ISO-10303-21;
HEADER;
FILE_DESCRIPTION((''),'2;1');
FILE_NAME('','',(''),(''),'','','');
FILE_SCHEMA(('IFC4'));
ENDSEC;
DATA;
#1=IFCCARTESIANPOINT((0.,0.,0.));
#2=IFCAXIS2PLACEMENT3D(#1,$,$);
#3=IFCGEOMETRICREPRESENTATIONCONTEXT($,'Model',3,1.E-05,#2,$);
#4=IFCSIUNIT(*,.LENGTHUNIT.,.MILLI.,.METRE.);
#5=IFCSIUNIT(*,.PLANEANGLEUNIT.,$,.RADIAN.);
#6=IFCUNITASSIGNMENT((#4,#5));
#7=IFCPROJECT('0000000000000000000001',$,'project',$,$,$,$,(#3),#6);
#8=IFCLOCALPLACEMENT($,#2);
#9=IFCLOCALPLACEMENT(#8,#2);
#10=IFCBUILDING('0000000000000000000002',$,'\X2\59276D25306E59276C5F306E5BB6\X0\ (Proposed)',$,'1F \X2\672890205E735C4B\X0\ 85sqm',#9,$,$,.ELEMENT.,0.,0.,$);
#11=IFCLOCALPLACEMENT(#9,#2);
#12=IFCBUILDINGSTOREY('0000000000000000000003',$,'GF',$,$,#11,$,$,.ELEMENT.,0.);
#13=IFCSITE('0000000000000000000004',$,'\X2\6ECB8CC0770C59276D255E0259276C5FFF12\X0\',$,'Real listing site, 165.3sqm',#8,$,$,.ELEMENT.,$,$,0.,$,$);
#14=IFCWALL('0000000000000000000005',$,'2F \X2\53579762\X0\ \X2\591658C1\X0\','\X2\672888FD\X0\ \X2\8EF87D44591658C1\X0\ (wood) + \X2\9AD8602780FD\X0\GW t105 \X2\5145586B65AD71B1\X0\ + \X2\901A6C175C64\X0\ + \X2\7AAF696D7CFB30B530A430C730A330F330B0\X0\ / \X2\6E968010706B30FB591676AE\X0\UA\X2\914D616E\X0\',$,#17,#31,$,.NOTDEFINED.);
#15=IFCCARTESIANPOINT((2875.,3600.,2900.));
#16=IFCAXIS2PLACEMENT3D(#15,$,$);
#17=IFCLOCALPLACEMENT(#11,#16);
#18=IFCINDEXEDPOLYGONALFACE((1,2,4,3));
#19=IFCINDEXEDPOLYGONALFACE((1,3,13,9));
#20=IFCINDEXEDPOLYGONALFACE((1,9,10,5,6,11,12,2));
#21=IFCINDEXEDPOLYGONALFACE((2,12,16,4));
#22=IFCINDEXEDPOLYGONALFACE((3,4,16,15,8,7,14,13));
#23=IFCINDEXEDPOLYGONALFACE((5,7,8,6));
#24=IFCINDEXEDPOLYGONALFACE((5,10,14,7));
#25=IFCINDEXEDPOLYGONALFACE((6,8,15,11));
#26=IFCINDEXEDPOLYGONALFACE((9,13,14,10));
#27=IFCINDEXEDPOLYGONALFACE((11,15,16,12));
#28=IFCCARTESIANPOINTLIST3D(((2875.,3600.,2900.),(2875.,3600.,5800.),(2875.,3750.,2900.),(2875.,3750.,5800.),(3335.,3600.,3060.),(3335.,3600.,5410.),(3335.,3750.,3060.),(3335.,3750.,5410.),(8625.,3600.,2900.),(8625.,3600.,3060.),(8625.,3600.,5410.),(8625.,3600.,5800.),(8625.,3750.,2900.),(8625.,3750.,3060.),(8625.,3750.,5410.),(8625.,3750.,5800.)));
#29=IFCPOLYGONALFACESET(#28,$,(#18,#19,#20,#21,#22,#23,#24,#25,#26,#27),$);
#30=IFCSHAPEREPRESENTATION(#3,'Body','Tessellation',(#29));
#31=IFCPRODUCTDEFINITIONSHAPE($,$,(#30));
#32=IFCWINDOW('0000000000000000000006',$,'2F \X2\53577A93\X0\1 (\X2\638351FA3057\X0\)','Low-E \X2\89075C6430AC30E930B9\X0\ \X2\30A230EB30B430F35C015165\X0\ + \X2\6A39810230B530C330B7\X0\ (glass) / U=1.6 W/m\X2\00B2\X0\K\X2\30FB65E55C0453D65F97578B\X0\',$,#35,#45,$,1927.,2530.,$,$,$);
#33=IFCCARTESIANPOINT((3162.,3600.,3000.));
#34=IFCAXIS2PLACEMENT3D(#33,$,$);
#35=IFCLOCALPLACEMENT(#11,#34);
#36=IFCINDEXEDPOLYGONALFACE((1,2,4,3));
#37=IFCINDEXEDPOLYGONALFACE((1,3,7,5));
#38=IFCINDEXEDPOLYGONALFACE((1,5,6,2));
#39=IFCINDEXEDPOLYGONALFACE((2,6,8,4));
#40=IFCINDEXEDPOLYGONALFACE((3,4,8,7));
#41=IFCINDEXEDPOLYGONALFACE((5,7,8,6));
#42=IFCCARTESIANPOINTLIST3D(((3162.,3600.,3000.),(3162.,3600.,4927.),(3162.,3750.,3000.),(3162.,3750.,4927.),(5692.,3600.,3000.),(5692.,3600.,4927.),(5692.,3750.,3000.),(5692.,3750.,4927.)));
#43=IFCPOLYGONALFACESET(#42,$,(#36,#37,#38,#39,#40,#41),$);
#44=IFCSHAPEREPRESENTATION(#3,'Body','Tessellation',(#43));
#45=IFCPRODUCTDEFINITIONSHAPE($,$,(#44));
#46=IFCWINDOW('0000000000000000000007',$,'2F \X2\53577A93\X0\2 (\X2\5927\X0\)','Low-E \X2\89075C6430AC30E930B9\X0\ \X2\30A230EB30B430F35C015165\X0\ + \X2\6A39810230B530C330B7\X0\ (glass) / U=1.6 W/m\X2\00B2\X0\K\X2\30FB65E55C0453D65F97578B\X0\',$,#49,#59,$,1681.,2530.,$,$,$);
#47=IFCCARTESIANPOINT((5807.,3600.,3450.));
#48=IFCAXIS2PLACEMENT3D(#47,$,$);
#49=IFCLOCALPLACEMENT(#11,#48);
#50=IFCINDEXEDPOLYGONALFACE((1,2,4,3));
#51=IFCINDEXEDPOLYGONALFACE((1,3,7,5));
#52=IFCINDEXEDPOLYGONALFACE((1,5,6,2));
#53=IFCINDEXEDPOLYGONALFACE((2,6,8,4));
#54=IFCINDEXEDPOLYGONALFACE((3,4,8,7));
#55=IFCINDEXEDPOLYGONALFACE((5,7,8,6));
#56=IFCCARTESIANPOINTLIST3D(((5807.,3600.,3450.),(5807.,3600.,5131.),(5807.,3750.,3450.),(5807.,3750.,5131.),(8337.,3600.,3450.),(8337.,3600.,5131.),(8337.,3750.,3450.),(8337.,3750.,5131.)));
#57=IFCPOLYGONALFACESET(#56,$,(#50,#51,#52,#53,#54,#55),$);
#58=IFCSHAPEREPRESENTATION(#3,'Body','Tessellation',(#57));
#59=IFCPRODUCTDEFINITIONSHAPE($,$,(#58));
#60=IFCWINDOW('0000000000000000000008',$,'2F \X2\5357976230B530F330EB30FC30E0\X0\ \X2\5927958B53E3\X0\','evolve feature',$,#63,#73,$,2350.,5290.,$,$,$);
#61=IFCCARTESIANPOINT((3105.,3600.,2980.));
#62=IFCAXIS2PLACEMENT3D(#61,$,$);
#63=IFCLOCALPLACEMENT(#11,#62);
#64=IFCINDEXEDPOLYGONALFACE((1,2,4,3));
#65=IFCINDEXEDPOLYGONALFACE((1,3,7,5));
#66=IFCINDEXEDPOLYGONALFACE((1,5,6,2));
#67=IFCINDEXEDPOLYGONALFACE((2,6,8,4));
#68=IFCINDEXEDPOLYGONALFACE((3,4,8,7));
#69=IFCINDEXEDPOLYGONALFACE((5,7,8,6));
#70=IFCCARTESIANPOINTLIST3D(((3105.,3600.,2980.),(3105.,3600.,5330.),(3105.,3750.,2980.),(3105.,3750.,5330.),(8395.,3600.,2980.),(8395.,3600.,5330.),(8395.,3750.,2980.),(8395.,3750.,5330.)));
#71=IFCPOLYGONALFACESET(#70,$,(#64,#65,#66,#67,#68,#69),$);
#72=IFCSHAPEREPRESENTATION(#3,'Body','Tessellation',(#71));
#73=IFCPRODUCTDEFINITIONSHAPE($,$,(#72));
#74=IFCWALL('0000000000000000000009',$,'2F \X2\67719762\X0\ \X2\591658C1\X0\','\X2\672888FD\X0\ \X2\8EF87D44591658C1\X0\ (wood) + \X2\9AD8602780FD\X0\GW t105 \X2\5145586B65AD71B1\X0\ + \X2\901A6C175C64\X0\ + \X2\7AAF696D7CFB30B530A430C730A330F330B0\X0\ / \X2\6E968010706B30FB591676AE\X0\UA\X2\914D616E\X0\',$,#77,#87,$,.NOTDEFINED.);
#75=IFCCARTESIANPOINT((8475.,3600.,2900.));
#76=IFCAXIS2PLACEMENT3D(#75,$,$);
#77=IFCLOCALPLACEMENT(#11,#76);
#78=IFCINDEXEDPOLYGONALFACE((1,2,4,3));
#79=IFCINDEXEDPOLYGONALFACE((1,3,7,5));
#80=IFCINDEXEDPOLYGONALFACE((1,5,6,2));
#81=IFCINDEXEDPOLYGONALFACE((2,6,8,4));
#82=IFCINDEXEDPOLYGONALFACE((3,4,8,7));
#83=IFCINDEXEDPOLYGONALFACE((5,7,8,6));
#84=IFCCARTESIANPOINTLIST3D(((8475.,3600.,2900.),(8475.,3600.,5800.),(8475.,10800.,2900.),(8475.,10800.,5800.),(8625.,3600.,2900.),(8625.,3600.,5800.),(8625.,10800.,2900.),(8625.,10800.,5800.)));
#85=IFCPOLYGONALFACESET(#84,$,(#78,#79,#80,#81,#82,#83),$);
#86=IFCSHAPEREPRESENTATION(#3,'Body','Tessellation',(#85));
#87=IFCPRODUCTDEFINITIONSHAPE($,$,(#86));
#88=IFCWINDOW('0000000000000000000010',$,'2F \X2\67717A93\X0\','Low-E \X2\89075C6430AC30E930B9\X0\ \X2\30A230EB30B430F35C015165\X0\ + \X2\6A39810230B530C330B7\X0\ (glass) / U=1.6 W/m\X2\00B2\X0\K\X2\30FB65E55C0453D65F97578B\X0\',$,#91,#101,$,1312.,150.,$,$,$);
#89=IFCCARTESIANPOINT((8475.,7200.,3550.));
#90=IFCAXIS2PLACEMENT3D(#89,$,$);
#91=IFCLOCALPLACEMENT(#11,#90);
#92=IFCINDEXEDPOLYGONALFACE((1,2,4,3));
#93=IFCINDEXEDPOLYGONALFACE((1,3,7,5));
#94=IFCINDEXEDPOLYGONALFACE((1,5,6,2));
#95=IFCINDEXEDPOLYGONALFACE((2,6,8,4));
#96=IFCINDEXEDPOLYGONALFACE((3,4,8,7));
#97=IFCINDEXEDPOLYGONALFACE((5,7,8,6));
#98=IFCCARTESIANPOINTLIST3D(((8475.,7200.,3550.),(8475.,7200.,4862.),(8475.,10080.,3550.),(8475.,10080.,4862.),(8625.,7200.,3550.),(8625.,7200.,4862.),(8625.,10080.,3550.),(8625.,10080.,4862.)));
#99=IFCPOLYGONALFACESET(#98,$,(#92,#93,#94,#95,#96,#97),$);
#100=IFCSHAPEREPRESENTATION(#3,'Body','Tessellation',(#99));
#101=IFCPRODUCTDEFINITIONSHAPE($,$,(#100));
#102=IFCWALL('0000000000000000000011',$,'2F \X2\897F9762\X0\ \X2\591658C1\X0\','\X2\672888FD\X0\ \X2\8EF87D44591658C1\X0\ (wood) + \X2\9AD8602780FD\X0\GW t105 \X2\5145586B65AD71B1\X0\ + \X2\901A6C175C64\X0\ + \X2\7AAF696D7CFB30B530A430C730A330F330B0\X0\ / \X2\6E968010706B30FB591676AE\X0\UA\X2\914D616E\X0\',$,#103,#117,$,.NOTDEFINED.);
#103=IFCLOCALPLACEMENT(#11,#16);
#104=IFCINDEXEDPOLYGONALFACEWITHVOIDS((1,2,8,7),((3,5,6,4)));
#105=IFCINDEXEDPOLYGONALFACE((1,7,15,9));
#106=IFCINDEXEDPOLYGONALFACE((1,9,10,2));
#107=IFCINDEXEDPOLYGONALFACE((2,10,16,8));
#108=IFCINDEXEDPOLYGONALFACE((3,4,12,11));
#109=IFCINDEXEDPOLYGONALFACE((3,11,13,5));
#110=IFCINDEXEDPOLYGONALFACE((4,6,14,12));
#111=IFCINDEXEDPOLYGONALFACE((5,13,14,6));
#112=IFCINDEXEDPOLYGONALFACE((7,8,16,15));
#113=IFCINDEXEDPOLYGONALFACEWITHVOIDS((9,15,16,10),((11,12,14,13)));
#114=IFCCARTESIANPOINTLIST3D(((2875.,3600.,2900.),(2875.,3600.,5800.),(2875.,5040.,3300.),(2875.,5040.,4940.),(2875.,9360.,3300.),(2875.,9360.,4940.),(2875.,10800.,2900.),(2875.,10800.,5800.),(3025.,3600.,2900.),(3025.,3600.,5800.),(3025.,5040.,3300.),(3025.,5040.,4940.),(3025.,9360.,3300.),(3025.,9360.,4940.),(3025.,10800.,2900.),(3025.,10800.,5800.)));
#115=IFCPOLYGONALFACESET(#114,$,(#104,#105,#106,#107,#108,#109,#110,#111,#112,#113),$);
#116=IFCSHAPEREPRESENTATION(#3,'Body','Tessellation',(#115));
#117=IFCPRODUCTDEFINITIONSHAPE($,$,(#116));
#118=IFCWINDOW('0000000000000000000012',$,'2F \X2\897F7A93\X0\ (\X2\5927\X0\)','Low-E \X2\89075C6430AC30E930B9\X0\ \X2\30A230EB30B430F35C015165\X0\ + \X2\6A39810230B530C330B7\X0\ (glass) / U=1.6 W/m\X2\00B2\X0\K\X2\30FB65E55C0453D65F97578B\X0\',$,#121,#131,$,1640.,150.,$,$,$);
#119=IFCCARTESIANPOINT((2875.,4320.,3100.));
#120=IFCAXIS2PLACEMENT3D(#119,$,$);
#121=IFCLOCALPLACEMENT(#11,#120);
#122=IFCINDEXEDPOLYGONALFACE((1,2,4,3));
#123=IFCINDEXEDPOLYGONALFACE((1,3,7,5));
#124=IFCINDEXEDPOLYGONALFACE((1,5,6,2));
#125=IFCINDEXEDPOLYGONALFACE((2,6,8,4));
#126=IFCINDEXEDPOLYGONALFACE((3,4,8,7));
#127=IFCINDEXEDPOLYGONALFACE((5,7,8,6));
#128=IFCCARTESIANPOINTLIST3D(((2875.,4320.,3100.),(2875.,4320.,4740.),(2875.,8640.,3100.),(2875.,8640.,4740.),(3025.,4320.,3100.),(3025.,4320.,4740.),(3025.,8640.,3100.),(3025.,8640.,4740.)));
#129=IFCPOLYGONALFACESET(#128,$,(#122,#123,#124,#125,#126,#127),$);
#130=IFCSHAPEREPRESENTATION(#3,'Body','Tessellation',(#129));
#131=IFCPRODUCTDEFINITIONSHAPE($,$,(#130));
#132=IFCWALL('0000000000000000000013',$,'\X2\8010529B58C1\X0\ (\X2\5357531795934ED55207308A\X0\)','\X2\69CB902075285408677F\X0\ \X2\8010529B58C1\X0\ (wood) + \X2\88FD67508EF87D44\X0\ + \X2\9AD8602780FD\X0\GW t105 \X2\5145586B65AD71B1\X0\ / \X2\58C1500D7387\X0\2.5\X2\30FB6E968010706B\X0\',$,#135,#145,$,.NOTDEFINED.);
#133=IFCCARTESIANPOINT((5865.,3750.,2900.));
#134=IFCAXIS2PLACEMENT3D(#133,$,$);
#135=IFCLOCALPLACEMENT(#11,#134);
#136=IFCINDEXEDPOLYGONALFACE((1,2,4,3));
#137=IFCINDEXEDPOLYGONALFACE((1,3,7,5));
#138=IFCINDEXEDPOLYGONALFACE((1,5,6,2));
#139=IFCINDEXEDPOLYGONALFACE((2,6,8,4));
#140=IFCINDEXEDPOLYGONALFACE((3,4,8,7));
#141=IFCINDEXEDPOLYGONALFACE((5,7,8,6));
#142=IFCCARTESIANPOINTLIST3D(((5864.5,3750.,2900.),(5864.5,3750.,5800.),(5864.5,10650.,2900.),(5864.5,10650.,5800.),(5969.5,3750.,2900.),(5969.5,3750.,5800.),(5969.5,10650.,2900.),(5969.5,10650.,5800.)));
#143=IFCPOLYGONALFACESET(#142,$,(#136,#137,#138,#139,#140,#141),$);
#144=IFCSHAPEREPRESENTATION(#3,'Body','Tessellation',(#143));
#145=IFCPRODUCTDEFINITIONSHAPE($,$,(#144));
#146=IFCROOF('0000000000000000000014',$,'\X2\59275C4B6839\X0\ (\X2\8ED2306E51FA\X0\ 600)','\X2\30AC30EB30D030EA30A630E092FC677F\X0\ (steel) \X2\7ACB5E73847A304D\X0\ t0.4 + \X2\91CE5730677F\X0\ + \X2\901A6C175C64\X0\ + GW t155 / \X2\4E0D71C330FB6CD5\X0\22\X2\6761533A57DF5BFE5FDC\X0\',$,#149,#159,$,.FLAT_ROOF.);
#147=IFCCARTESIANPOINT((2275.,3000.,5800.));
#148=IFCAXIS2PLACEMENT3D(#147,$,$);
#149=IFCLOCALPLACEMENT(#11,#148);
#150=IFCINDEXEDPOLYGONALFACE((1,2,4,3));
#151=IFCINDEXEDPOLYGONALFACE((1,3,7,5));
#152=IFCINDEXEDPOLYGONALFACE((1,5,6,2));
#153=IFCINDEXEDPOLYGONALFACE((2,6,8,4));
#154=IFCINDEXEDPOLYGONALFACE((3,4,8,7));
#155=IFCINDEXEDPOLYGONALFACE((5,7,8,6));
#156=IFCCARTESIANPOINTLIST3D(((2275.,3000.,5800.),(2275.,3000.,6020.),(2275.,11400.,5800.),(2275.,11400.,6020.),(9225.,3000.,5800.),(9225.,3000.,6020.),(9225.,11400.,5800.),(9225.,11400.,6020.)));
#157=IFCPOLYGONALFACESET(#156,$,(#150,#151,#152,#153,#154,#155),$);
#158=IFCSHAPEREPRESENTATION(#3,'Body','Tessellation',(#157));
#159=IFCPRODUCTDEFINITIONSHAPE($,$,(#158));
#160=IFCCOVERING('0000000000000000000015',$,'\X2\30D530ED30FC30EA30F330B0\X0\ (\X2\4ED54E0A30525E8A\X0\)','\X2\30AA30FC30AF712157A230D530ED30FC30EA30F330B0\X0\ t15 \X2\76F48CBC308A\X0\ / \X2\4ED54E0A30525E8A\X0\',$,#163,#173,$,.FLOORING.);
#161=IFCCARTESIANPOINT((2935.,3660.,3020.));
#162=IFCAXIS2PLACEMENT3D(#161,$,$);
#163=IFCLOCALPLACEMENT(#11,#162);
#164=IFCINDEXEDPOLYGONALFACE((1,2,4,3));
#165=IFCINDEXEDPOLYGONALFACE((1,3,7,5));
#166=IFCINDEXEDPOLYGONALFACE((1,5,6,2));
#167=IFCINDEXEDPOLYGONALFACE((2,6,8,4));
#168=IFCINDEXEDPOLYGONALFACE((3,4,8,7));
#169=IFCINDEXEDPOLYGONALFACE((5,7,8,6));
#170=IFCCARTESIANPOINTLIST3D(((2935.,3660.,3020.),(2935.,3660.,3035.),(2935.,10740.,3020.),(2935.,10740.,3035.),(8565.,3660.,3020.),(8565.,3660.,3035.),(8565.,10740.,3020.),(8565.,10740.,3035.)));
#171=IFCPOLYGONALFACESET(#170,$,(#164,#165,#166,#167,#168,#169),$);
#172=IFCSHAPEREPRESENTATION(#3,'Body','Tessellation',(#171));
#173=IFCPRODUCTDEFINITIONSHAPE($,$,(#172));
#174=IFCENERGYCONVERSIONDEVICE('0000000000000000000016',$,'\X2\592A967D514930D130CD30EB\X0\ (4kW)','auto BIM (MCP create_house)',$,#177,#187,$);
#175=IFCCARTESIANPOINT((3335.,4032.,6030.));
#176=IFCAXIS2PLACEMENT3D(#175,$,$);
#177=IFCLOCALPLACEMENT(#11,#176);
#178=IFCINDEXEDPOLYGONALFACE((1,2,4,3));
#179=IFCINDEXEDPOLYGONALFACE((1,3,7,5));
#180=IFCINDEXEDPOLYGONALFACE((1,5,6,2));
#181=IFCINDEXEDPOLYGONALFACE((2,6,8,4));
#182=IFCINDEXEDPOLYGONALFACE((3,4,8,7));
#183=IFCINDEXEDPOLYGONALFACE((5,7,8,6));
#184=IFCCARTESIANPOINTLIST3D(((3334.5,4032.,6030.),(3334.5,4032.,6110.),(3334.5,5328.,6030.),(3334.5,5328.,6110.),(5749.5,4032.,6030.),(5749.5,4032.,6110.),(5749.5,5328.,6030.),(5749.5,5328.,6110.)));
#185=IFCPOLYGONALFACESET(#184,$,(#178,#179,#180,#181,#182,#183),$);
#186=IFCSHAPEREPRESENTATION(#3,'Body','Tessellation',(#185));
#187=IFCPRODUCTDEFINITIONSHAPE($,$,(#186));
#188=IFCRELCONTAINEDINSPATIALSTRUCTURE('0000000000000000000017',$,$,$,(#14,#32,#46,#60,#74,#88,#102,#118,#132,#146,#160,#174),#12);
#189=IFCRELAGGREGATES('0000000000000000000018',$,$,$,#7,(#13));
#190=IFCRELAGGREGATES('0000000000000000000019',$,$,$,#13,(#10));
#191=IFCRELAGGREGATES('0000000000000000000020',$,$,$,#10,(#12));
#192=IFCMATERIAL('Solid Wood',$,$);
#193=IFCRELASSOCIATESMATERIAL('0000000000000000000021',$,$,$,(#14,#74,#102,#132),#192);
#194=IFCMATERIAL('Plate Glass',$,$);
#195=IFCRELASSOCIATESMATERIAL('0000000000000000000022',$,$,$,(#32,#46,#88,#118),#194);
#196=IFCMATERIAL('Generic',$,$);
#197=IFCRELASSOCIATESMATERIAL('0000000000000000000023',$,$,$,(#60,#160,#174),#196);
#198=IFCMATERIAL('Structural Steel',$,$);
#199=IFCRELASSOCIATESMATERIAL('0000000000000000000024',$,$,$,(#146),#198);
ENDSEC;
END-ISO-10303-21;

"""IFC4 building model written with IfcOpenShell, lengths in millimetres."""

from ifc_helpers import new_model, si_unit, frame, frame_2d, origin, place, context, project, spatial, rectangle, extrude, material, element, fill, save


model = new_model("IFC4")

# Units and contexts
model_context = context("Model", 3, precision=1e-05, world=origin())
ifc_project = project(units=[si_unit("LENGTHUNIT", "METRE", prefix="MILLI"), si_unit("PLANEANGLEUNIT", "RADIAN")], contexts=[model_context])

# Site, building, storey
site_placement = place(None, origin())
site = spatial("IfcSite", under=ifc_project, at=site_placement, Name="滋賀県大津市大江２", ObjectType="Real listing site, 165.3sqm", CompositionType="ELEMENT", RefElevation=0.0)
building_placement = place(site_placement, origin())
building = spatial("IfcBuilding", under=site, at=building_placement, Name="大津の大江の家 (Proposed)", ObjectType="1F 木造平屋 85sqm", CompositionType="ELEMENT", ElevationOfRefHeight=0.0, ElevationOfTerrain=0.0)
storey_placement = place(building_placement, origin())
storey = spatial("IfcBuildingStorey", under=building, at=storey_placement, Name="GF", CompositionType="ELEMENT", Elevation=0.0)

# Shared definitions
ifc_material_1 = material(Name="Solid Wood")

# Wall, openings, windows
wall_1_placement = place(storey_placement, frame((2875.0, 3600.0, 2900.0)))
wall_1 = element("IfcWall", 1, at=wall_1_placement, inside=storey, material=ifc_material_1, Name="2F 南面 外壁", Description="木製 軸組外壁 (wood) + 高性能GW t105 充填断熱 + 通気層 + 窯業系サイディング / 準耐火・外皮UA配慮", PredefinedType="NOTDEFINED", context=model_context, shape_type="SweptSolid", body=[
    extrude(rectangle(XDim=5750.0, YDim=150.0, at=frame_2d((2875.0, 75.0))), frame((2875.0, 3600.0, 2900.0)), (0.0, 0.0, 1.0), 2900.0),
])
opening_1_placement = place(storey_placement, frame((3162.0, 3600.0, 3000.0)))
opening_1 = element("IfcOpeningElement", 2, at=opening_1_placement, cuts=wall_1, PredefinedType="NOTDEFINED", context=model_context, shape_type="SweptSolid", body=[
    extrude(rectangle(XDim=2530.0, YDim=150.0, at=frame_2d((1265.0, 75.0))), frame((3162.0, 3600.0, 3000.0)), (0.0, 0.0, 1.0), 1927.0),
])
opening_2_placement = place(storey_placement, frame((5807.0, 3600.0, 3450.0)))
opening_2 = element("IfcOpeningElement", 3, at=opening_2_placement, cuts=wall_1, PredefinedType="NOTDEFINED", context=model_context, shape_type="SweptSolid", body=[
    extrude(rectangle(XDim=2530.0, YDim=150.0, at=frame_2d((1265.0, 75.0))), frame((5807.0, 3600.0, 3450.0)), (0.0, 0.0, 1.0), 1681.0),
])
opening_3_placement = place(storey_placement, frame((3105.0, 3600.0, 2980.0)))
opening_3 = element("IfcOpeningElement", 4, at=opening_3_placement, cuts=wall_1, PredefinedType="NOTDEFINED", context=model_context, shape_type="SweptSolid", body=[
    extrude(rectangle(XDim=5290.0, YDim=150.0, at=frame_2d((2645.0, 75.0))), frame((3105.0, 3600.0, 2980.0)), (0.0, 0.0, 1.0), 2350.0),
])
ifc_material_2 = material(Name="Plate Glass")
window_1_placement = place(storey_placement, frame((3162.0, 3600.0, 3000.0)))
window_1 = element("IfcWindow", 5, at=window_1_placement, inside=storey, material=ifc_material_2, Name="2F 南窓1 (掃出し)", Description="Low-E 複層ガラス アルゴン封入 + 樹脂サッシ (glass) / U=1.6 W/m²K・日射取得型", OverallHeight=1927.0, OverallWidth=2530.0, context=model_context, shape_type="SweptSolid", body=[
    extrude(rectangle(XDim=2530.0, YDim=150.0, at=frame_2d((1265.0, 75.0))), frame((3162.0, 3600.0, 3000.0)), (0.0, 0.0, 1.0), 1927.0),
])
fill(opening_1, window_1)
window_2_placement = place(storey_placement, frame((5807.0, 3600.0, 3450.0)))
window_2 = element("IfcWindow", 6, at=window_2_placement, inside=storey, material=ifc_material_2, Name="2F 南窓2 (大)", Description="Low-E 複層ガラス アルゴン封入 + 樹脂サッシ (glass) / U=1.6 W/m²K・日射取得型", OverallHeight=1681.0, OverallWidth=2530.0, context=model_context, shape_type="SweptSolid", body=[
    extrude(rectangle(XDim=2530.0, YDim=150.0, at=frame_2d((1265.0, 75.0))), frame((5807.0, 3600.0, 3450.0)), (0.0, 0.0, 1.0), 1681.0),
])
fill(opening_2, window_2)
ifc_material_3 = material(Name="Generic")
window_3_placement = place(storey_placement, frame((3105.0, 3600.0, 2980.0)))
window_3 = element("IfcWindow", 7, at=window_3_placement, inside=storey, material=ifc_material_3, Name="2F 南面サンルーム 大開口", Description="evolve feature", OverallHeight=2350.0, OverallWidth=5290.0, context=model_context, shape_type="SweptSolid", body=[
    extrude(rectangle(XDim=5290.0, YDim=150.0, at=frame_2d((2645.0, 75.0))), frame((3105.0, 3600.0, 2980.0)), (0.0, 0.0, 1.0), 2350.0),
])
fill(opening_3, window_3)

# Walls, openings, windows
wall_2_placement = place(storey_placement, frame((8475.0, 3600.0, 2900.0)))
wall_2 = element("IfcWall", 8, at=wall_2_placement, inside=storey, material=ifc_material_1, Name="2F 東面 外壁", Description="木製 軸組外壁 (wood) + 高性能GW t105 充填断熱 + 通気層 + 窯業系サイディング / 準耐火・外皮UA配慮", PredefinedType="NOTDEFINED", context=model_context, shape_type="SweptSolid", body=[
    extrude(rectangle(XDim=150.0, YDim=7200.0, at=frame_2d((75.0, 3600.0))), frame((8475.0, 3600.0, 2900.0)), (0.0, 0.0, 1.0), 2900.0),
])
opening_4_placement = place(storey_placement, frame((8475.0, 7200.0, 3550.0)))
opening_4 = element("IfcOpeningElement", 9, at=opening_4_placement, cuts=wall_2, PredefinedType="NOTDEFINED", context=model_context, shape_type="SweptSolid", body=[
    extrude(rectangle(XDim=150.0, YDim=2880.0, at=frame_2d((75.0, 1440.0))), frame((8475.0, 7200.0, 3550.0)), (0.0, 0.0, 1.0), 1312.0),
])
window_4_placement = place(storey_placement, frame((8475.0, 7200.0, 3550.0)))
window_4 = element("IfcWindow", 10, at=window_4_placement, inside=storey, material=ifc_material_2, Name="2F 東窓", Description="Low-E 複層ガラス アルゴン封入 + 樹脂サッシ (glass) / U=1.6 W/m²K・日射取得型", OverallHeight=1312.0, OverallWidth=150.0, context=model_context, shape_type="SweptSolid", body=[
    extrude(rectangle(XDim=150.0, YDim=2880.0, at=frame_2d((75.0, 1440.0))), frame((8475.0, 7200.0, 3550.0)), (0.0, 0.0, 1.0), 1312.0),
])
fill(opening_4, window_4)
wall_3_placement = place(storey_placement, frame((2875.0, 3600.0, 2900.0)))
wall_3 = element("IfcWall", 11, at=wall_3_placement, inside=storey, material=ifc_material_1, Name="2F 西面 外壁", Description="木製 軸組外壁 (wood) + 高性能GW t105 充填断熱 + 通気層 + 窯業系サイディング / 準耐火・外皮UA配慮", PredefinedType="NOTDEFINED", context=model_context, shape_type="SweptSolid", body=[
    extrude(rectangle(XDim=150.0, YDim=7200.0, at=frame_2d((75.0, 3600.0))), frame((2875.0, 3600.0, 2900.0)), (0.0, 0.0, 1.0), 2900.0),
])
opening_5_placement = place(storey_placement, frame((2875.0, 4320.0, 3100.0)))
opening_5 = element("IfcOpeningElement", 12, at=opening_5_placement, cuts=wall_3, PredefinedType="NOTDEFINED", context=model_context, shape_type="SweptSolid", body=[
    extrude(rectangle(XDim=150.0, YDim=4320.0, at=frame_2d((75.0, 2160.0))), frame((2875.0, 4320.0, 3100.0)), (0.0, 0.0, 1.0), 1640.0),
])
window_5_placement = place(storey_placement, frame((2875.0, 4320.0, 3100.0)))
window_5 = element("IfcWindow", 13, at=window_5_placement, inside=storey, material=ifc_material_2, Name="2F 西窓 (大)", Description="Low-E 複層ガラス アルゴン封入 + 樹脂サッシ (glass) / U=1.6 W/m²K・日射取得型", OverallHeight=1640.0, OverallWidth=150.0, context=model_context, shape_type="SweptSolid", body=[
    extrude(rectangle(XDim=150.0, YDim=4320.0, at=frame_2d((75.0, 2160.0))), frame((2875.0, 4320.0, 3100.0)), (0.0, 0.0, 1.0), 1640.0),
])
fill(opening_5, window_5)

# Wall
wall_4_placement = place(storey_placement, frame((5865.0, 3750.0, 2900.0)))
element("IfcWall", 14, at=wall_4_placement, inside=storey, material=ifc_material_1, Name="耐力壁 (南北間仕切り)", Description="構造用合板 耐力壁 (wood) + 製材軸組 + 高性能GW t105 充填断熱 / 壁倍率2.5・準耐火", PredefinedType="NOTDEFINED", context=model_context, shape_type="SweptSolid", body=[
    extrude(rectangle(XDim=105.0, YDim=6900.0, at=frame_2d((52.0, 3450.0))), frame((5865.0, 3750.0, 2900.0)), (0.0, 0.0, 1.0), 2900.0),
])

# Roof
ifc_material_4 = material(Name="Structural Steel")
roof_placement = place(storey_placement, frame((2275.0, 3000.0, 5800.0)))
element("IfcRoof", 15, at=roof_placement, inside=storey, material=ifc_material_4, Name="大屋根 (軒の出 600)", Description="ガルバリウム鋼板 (steel) 立平葺き t0.4 + 野地板 + 通気層 + GW t155 / 不燃・法22条区域対応", PredefinedType="FLAT_ROOF", context=model_context, shape_type="SweptSolid", body=[
    extrude(rectangle(XDim=6950.0, YDim=8400.0, at=frame_2d((3475.0, 4200.0))), frame((2275.0, 3000.0, 5800.0)), (0.0, 0.0, 1.0), 220.0),
])

# Covering
covering_placement = place(storey_placement, frame((2935.0, 3660.0, 3020.0)))
element("IfcCovering", 16, at=covering_placement, inside=storey, material=ifc_material_3, Name="フローリング (仕上げ床)", Description="オーク無垢フローリング t15 直貼り / 仕上げ床", PredefinedType="FLOORING", context=model_context, shape_type="SweptSolid", body=[
    extrude(rectangle(XDim=5630.0, YDim=7080.0, at=frame_2d((2815.0, 3540.0))), frame((2935.0, 3660.0, 3020.0)), (0.0, 0.0, 1.0), 15.0),
])

# Energy conversion device
energy_conversion_device_placement = place(storey_placement, frame((3335.0, 4032.0, 6030.0)))
element("IfcEnergyConversionDevice", 17, at=energy_conversion_device_placement, inside=storey, material=ifc_material_3, Name="太陽光パネル (4kW)", Description="auto BIM (MCP create_house)", context=model_context, shape_type="SweptSolid", body=[
    extrude(rectangle(XDim=2415.0, YDim=1296.0, at=frame_2d((1207.0, 648.0))), frame((3335.0, 4032.0, 6030.0)), (0.0, 0.0, 1.0), 80.0),
])

save(model, "model.ifc")
